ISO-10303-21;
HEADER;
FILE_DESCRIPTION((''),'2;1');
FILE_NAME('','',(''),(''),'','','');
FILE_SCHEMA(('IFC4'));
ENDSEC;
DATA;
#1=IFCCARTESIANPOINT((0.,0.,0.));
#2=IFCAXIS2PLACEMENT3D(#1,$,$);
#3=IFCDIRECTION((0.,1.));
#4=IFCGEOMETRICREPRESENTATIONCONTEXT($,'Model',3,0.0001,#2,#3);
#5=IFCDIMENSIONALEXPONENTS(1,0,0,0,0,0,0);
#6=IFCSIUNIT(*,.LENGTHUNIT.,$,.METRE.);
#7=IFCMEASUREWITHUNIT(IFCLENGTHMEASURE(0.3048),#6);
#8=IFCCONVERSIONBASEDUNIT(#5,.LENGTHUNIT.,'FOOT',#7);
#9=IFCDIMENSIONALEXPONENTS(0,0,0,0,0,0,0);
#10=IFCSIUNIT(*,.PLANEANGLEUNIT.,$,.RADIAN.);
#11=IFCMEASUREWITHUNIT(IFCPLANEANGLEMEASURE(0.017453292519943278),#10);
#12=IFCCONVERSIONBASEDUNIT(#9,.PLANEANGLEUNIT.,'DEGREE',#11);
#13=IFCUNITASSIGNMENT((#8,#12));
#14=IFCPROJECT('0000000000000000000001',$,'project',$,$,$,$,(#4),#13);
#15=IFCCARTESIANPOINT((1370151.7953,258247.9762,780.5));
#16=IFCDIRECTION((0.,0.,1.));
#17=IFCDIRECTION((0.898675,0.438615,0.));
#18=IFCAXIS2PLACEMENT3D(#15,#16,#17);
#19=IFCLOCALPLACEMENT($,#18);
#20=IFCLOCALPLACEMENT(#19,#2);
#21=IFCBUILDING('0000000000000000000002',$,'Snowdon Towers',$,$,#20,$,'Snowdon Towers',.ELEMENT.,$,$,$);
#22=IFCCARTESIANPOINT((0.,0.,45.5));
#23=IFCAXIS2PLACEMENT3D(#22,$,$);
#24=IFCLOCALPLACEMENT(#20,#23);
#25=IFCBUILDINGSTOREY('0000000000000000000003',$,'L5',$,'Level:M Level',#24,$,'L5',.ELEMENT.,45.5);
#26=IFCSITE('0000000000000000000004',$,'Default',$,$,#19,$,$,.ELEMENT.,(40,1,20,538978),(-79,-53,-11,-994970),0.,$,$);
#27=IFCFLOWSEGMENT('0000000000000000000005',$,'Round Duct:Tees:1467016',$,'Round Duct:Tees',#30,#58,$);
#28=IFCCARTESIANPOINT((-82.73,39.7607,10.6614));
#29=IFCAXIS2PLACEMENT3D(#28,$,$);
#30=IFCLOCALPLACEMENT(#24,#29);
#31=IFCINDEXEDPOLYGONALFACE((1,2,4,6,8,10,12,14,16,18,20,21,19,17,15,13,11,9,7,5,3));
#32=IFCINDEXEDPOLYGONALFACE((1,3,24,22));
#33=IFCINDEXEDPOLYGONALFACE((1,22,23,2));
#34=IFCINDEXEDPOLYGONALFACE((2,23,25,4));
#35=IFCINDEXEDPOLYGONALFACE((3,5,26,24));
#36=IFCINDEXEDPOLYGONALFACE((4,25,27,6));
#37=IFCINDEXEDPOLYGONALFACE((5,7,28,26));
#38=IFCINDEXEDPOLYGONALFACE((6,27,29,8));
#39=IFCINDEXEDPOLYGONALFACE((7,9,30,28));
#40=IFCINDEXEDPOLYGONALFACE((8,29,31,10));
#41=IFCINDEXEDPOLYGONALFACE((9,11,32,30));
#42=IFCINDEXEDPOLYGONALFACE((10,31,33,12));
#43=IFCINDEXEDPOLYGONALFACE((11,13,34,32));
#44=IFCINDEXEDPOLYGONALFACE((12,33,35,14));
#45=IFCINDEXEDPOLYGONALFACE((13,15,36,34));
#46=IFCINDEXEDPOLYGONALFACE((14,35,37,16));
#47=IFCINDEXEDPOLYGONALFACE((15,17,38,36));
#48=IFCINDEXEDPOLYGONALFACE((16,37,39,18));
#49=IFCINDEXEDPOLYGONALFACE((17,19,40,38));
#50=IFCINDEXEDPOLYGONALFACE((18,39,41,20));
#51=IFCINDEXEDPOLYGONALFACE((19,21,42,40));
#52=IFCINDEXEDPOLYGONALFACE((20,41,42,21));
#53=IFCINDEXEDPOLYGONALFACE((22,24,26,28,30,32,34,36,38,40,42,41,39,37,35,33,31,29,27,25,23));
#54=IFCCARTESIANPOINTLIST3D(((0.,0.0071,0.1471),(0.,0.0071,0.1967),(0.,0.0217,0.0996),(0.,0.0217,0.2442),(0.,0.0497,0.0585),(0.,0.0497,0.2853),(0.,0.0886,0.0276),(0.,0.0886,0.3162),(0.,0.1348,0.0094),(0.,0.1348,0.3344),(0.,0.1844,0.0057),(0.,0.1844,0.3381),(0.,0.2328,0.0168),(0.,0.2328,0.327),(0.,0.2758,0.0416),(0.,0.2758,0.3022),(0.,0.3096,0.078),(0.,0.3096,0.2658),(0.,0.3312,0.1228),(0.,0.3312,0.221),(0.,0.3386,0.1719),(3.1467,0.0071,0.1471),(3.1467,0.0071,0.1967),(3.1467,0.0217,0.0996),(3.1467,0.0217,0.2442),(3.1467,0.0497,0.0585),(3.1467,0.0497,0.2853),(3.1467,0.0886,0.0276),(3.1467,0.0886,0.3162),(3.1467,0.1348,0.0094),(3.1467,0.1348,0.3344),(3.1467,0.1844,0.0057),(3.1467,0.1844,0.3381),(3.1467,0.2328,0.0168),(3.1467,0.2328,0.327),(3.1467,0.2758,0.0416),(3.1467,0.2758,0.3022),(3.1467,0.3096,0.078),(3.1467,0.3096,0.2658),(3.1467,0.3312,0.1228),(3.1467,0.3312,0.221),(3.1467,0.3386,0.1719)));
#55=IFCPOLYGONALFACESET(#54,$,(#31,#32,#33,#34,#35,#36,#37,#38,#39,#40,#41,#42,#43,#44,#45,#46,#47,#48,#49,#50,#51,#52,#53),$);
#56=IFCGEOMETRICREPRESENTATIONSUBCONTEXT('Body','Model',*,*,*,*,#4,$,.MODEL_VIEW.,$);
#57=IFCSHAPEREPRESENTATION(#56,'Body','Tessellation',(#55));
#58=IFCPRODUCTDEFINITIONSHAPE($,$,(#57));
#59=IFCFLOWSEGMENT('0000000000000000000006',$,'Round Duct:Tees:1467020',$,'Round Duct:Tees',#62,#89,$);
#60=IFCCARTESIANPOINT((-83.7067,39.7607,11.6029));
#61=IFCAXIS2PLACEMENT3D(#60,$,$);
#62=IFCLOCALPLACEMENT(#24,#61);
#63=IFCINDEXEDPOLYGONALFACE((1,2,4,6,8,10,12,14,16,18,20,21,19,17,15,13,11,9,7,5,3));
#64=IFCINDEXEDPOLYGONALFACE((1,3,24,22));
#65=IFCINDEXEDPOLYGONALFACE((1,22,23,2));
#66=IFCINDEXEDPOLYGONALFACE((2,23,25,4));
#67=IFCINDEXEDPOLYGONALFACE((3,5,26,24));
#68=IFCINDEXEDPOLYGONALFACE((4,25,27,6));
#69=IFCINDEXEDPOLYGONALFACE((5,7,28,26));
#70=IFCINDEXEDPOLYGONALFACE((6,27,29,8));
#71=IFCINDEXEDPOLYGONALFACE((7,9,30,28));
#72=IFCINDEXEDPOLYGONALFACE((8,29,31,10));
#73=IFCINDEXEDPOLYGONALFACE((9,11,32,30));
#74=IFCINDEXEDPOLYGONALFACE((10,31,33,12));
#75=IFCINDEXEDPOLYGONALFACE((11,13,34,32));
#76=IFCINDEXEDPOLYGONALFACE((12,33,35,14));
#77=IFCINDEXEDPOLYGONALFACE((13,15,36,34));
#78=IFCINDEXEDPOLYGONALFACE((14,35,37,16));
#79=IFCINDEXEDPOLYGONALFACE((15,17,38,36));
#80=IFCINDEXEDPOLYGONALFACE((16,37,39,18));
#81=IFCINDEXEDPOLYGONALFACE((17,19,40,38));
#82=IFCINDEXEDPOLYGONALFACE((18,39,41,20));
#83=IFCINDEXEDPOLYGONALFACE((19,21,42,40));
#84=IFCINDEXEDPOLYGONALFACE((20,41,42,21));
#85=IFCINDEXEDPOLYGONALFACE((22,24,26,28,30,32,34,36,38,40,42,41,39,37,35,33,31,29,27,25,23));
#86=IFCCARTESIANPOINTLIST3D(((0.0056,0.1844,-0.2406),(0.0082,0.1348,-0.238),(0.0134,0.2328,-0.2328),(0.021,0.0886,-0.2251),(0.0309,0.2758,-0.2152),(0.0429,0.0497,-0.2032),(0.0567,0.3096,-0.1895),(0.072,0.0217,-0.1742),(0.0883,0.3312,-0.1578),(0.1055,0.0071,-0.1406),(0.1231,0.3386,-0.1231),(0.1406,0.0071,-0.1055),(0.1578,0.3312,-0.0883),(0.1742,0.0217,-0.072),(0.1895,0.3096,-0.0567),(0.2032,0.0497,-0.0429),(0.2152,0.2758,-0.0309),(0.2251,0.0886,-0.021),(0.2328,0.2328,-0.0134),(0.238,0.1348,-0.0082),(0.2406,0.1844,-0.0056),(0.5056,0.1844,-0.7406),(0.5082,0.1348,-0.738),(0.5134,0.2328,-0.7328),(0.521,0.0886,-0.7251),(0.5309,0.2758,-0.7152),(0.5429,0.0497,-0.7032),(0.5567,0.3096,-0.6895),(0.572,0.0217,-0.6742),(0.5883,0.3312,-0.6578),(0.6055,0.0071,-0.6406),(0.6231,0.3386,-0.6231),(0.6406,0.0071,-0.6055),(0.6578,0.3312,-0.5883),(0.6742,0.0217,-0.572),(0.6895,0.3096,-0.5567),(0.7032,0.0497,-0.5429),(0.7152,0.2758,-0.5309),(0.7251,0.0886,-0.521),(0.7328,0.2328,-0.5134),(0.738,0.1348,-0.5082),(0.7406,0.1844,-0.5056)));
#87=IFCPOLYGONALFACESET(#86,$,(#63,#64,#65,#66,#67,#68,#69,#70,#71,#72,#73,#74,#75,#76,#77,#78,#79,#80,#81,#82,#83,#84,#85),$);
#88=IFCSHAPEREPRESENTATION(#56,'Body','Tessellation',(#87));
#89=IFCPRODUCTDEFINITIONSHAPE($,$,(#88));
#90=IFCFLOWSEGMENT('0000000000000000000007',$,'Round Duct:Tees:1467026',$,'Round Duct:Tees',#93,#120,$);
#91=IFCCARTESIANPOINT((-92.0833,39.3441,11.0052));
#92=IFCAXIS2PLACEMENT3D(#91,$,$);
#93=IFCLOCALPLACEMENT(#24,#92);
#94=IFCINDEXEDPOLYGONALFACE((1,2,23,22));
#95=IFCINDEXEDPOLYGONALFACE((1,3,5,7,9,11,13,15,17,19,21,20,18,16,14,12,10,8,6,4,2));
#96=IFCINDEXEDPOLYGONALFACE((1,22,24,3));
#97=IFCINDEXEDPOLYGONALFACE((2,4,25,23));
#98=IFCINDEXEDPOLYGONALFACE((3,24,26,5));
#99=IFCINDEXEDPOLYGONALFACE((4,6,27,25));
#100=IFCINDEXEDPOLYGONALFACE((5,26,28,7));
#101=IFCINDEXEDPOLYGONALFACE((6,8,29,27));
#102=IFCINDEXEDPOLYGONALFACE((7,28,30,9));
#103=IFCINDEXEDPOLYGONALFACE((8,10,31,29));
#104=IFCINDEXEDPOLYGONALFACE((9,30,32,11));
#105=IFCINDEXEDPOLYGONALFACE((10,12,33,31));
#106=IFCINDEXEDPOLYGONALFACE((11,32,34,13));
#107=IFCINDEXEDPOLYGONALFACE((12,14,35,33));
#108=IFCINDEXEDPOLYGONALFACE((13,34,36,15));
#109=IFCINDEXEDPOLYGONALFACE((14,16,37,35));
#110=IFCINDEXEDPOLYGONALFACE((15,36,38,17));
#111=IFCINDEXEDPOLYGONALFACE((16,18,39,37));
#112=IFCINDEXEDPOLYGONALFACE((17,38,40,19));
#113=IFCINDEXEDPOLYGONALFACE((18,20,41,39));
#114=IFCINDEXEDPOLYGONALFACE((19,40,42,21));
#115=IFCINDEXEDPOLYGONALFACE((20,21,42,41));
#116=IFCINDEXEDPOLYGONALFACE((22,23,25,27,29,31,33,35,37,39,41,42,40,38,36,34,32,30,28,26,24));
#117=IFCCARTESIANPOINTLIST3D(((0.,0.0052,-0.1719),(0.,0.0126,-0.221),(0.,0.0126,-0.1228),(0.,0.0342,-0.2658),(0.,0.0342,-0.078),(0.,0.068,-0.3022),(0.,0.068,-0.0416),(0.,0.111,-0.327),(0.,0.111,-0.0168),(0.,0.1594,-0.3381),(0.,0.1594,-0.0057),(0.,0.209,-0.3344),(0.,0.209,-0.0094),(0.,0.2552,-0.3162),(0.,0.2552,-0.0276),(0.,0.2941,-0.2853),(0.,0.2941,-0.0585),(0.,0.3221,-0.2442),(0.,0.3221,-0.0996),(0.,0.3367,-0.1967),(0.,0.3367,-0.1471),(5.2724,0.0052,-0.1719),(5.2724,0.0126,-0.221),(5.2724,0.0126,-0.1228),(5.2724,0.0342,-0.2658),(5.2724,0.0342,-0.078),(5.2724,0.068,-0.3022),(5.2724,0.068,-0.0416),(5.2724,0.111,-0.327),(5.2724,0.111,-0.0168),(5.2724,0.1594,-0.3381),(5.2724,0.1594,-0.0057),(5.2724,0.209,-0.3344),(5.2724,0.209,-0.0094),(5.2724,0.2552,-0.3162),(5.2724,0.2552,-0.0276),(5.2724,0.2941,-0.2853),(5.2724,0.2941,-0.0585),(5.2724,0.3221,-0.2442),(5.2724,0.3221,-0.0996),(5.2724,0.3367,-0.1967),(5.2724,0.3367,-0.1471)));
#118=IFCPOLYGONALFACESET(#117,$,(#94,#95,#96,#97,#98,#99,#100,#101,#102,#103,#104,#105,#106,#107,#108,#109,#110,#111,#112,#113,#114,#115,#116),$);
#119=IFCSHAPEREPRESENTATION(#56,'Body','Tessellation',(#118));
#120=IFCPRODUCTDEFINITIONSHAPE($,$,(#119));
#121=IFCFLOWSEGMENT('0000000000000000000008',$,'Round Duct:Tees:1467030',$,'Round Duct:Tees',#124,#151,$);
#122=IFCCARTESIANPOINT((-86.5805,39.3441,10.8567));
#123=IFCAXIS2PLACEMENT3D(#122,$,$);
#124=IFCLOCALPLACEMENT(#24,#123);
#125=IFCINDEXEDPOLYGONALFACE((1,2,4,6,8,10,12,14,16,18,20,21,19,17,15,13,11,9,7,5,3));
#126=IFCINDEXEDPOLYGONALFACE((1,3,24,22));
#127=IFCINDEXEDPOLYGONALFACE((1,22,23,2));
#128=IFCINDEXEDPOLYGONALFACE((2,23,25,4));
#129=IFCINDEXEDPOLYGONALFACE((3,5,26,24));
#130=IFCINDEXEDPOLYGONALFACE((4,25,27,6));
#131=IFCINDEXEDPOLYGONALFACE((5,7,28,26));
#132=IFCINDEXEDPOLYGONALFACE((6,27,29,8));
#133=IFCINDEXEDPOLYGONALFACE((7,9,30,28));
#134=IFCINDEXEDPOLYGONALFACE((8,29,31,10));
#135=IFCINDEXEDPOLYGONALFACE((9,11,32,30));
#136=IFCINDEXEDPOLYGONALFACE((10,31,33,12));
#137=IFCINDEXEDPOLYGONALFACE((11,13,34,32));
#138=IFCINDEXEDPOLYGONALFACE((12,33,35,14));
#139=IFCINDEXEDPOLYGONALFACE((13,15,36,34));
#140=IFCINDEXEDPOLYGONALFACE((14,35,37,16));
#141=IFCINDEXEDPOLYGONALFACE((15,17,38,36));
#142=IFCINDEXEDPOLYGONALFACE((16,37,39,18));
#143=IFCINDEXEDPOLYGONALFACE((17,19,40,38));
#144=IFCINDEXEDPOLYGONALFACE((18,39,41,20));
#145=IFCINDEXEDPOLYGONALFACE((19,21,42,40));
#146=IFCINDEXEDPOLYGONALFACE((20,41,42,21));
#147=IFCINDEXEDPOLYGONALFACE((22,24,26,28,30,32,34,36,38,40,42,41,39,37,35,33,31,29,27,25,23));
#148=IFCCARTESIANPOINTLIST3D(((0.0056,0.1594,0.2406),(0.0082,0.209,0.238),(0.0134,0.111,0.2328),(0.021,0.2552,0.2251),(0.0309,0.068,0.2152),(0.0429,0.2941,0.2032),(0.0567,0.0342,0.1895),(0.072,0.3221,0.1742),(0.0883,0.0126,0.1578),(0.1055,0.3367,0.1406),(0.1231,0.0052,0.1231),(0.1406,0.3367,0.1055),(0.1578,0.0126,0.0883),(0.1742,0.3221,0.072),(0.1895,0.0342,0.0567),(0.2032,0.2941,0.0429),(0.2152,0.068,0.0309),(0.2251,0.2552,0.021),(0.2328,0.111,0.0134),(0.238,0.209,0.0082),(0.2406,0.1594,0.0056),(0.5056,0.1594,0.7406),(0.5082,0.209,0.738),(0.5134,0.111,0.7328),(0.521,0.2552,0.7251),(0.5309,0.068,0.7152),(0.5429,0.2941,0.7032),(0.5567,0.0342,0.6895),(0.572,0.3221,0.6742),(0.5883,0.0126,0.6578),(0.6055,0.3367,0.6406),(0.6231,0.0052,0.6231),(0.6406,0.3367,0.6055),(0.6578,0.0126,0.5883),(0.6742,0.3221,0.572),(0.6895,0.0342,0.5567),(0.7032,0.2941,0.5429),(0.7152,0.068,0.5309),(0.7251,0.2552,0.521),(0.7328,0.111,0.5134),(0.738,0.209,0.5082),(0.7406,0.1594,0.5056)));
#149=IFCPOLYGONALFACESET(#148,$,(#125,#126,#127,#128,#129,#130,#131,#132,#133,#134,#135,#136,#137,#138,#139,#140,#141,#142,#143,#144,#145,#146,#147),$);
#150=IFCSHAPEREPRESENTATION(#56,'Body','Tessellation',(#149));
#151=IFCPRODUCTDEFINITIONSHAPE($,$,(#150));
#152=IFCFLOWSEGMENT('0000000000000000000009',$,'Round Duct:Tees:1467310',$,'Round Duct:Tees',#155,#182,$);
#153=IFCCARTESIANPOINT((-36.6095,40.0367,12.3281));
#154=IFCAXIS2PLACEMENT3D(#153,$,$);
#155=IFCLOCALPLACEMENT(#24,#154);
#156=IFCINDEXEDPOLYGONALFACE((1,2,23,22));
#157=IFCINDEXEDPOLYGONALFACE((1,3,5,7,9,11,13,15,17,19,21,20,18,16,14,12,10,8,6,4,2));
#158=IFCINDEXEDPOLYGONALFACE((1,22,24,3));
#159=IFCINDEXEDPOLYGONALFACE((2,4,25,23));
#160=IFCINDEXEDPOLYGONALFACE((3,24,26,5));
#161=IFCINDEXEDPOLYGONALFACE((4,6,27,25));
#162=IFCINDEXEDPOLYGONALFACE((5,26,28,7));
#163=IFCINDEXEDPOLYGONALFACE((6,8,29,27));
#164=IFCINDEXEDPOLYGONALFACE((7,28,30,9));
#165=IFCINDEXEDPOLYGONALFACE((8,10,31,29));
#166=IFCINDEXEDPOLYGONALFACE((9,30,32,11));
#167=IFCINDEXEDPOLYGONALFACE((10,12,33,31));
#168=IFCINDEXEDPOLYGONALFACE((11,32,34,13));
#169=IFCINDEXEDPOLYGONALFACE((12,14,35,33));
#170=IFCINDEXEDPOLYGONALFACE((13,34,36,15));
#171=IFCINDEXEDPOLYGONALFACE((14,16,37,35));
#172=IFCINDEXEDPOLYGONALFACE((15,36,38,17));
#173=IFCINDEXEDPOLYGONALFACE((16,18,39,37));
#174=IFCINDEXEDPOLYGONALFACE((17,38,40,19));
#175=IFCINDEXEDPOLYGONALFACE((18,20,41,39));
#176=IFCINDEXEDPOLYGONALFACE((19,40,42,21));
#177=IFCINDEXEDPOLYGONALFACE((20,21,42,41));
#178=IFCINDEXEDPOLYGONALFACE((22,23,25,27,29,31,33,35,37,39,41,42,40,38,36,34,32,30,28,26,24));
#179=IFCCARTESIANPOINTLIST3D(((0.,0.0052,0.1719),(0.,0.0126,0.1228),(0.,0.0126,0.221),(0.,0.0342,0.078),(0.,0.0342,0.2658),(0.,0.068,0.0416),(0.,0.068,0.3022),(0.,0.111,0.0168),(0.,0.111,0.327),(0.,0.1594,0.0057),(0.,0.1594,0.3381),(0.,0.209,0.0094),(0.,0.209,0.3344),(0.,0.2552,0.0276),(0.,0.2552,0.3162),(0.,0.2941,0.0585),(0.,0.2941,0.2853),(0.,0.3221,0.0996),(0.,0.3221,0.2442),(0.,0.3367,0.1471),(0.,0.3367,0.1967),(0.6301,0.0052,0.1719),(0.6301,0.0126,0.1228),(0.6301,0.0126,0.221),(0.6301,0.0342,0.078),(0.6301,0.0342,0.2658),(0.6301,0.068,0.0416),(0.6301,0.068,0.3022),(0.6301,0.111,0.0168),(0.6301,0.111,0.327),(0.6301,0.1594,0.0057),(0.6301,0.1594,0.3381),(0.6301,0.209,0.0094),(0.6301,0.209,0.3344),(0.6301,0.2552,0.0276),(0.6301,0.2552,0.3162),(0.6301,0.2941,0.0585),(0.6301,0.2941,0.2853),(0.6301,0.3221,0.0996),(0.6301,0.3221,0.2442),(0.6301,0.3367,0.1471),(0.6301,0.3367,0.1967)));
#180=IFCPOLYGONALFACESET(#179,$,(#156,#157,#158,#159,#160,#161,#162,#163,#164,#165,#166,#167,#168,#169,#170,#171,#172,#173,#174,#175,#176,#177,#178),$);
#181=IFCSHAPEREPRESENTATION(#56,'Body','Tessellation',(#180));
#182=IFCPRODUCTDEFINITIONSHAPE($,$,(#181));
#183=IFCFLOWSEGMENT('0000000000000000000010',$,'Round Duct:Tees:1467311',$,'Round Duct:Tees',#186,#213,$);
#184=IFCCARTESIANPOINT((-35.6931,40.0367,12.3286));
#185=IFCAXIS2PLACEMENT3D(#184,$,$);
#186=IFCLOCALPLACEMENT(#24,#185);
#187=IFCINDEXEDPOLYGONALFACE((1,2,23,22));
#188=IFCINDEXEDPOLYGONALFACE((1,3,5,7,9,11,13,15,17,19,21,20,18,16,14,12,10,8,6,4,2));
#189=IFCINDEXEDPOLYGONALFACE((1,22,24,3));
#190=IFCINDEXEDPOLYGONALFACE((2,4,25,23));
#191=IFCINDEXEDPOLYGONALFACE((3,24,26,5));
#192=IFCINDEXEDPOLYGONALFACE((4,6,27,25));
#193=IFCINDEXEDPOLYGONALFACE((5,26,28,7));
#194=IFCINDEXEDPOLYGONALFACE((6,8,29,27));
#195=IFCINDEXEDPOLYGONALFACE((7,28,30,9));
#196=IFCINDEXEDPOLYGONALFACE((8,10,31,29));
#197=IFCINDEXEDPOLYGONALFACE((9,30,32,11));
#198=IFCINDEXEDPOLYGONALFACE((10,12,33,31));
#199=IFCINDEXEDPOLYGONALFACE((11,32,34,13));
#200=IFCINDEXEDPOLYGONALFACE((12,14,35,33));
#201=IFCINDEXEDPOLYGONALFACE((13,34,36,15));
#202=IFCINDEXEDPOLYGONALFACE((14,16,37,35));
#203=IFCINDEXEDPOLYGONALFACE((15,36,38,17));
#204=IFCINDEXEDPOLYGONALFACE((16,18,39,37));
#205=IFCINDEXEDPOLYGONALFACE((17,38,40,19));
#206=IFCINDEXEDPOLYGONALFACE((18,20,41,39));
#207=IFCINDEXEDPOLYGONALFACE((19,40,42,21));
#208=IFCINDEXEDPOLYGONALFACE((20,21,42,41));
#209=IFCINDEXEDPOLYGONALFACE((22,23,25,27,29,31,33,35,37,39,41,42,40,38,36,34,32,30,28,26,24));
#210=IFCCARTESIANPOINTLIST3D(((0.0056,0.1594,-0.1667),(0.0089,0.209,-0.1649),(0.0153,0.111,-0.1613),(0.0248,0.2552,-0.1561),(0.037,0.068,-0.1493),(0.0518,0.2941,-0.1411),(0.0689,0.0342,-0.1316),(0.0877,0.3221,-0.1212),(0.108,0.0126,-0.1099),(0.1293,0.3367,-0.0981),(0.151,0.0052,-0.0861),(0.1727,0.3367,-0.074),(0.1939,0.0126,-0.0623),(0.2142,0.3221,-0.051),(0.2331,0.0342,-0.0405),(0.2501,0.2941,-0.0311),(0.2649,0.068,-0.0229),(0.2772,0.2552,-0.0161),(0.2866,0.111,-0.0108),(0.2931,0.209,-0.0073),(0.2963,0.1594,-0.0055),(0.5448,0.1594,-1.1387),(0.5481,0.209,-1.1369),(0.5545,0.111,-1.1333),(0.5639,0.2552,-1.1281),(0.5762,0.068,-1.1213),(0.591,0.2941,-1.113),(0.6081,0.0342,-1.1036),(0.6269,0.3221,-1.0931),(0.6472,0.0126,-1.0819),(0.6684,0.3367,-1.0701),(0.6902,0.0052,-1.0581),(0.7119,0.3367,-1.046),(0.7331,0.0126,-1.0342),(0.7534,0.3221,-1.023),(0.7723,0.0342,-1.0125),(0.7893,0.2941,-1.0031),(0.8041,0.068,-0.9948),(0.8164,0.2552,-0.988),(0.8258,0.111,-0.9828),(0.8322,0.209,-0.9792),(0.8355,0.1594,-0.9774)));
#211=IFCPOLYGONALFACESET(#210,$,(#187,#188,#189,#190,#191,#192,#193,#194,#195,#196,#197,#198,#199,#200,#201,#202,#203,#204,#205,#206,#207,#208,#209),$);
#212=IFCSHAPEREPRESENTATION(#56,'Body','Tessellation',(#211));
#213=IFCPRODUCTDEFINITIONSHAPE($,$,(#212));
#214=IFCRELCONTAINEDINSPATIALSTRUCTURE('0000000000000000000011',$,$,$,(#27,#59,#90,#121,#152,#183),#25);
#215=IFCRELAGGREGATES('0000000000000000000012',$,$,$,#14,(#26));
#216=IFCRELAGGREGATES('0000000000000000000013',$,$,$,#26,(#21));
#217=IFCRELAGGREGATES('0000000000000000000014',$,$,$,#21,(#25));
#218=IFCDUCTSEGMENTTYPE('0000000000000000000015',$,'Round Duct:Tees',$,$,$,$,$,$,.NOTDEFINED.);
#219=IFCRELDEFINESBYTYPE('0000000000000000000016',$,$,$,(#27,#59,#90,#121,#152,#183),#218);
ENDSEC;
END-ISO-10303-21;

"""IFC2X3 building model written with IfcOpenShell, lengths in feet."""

from ifc_helpers import new_model, entity, si_unit, converted_unit, direction, frame, frame_2d, origin, origin_2d_with_axis, place, context, subcontext, project, spatial, circle, extrude, type_object, element, save


model = new_model("IFC2X3")

# Units and contexts
model_context = context("Model", 3, precision=0.0001, world=origin(), true_north=direction((0.0, 1.0)))
body_context = subcontext(model_context, "Body", "Model", "MODEL_VIEW")
ifc_project = project(units=[converted_unit("LENGTHUNIT", "FOOT", entity("IfcLengthMeasure", 0.3048), si_unit("LENGTHUNIT", "METRE"), dimensions=[1, 0, 0, 0, 0, 0, 0]), converted_unit("PLANEANGLEUNIT", "DEGREE", entity("IfcPlaneAngleMeasure", 0.017453292519943278), si_unit("PLANEANGLEUNIT", "RADIAN"), dimensions=[0, 0, 0, 0, 0, 0, 0])], contexts=[model_context])

# Site, building, storey
site_placement = place(None, frame((1370151.7953, 258247.9762, 780.5), z_axis=(0.0, 0.0, 1.0), x_axis=(0.898675, 0.438615, 0.0)))
site = spatial("IfcSite", under=ifc_project, at=site_placement, Name="Default", CompositionType="ELEMENT", RefLatitude=(40, 1, 20, 538978), RefLongitude=(-79, -53, -11, -994970), RefElevation=0.0)
building_placement = place(site_placement, origin())
building = spatial("IfcBuilding", under=site, at=building_placement, Name="Snowdon Towers", LongName="Snowdon Towers", CompositionType="ELEMENT")
storey_placement = place(building_placement, frame((0.0, 0.0, 45.5)))
storey = spatial("IfcBuildingStorey", under=building, at=storey_placement, Name="L5", ObjectType="Level:M Level", LongName="L5", CompositionType="ELEMENT", Elevation=45.5)

# Flow segments
duct_segment_type = type_object("IfcDuctSegmentType", Name="Round Duct:Tees", PredefinedType="NOTDEFINED")
flow_segment_1_placement = place(storey_placement, frame((-82.73, 39.7607, 10.6614)))
element("IfcFlowSegment", 1, at=flow_segment_1_placement, inside=storey, type_object=duct_segment_type, Name="Round Duct:Tees:1467016", ObjectType="Round Duct:Tees", context=body_context, shape_type="SweptSolid", body=[
    extrude(circle(Radius=0.1667, at=frame_2d((0.0, 0.0), x_axis=(1.0, 0.0))), frame((0.0, 0.1719, 0.1719), z_axis=(1.0, 0.0, 0.0), x_axis=(0.0, 1.0, 0.0)), (0.0, 0.0, 1.0), 3.1467),
])
flow_segment_2_placement = place(storey_placement, frame((-83.7067, 39.7607, 11.6029)))
element("IfcFlowSegment", 2, at=flow_segment_2_placement, inside=storey, type_object=duct_segment_type, Name="Round Duct:Tees:1467020", ObjectType="Round Duct:Tees", context=body_context, shape_type="SweptSolid", body=[
    extrude(circle(Radius=0.1667, at=frame_2d((0.0, 0.0), x_axis=(1.0, 0.0))), frame((0.1231, 0.1719, -0.1231), z_axis=(0.707107, 0.0, -0.707107), x_axis=(0.0, 1.0, 0.0)), (0.0, 0.0, 1.0), 0.7071),
])
flow_segment_3_placement = place(storey_placement, frame((-92.0833, 39.3441, 11.0052)))
element("IfcFlowSegment", 3, at=flow_segment_3_placement, inside=storey, type_object=duct_segment_type, Name="Round Duct:Tees:1467026", ObjectType="Round Duct:Tees", context=body_context, shape_type="SweptSolid", body=[
    extrude(circle(Radius=0.1667, at=origin_2d_with_axis()), frame((0.0, 0.1719, -0.1719), z_axis=(1.0, 0.0, 0.0), x_axis=(0.0, -1.0, 0.0)), (0.0, 0.0, 1.0), 5.2724),
])
flow_segment_4_placement = place(storey_placement, frame((-86.5805, 39.3441, 10.8567)))
element("IfcFlowSegment", 4, at=flow_segment_4_placement, inside=storey, type_object=duct_segment_type, Name="Round Duct:Tees:1467030", ObjectType="Round Duct:Tees", context=body_context, shape_type="SweptSolid", body=[
    extrude(circle(Radius=0.1667, at=origin_2d_with_axis()), frame((0.1231, 0.1719, 0.1231), z_axis=(0.707107, 0.0, 0.707107), x_axis=(0.0, -1.0, 0.0)), (0.0, 0.0, 1.0), 0.7071),
])
flow_segment_5_placement = place(storey_placement, frame((-36.6095, 40.0367, 12.3281)))
element("IfcFlowSegment", 5, at=flow_segment_5_placement, inside=storey, type_object=duct_segment_type, Name="Round Duct:Tees:1467310", ObjectType="Round Duct:Tees", context=body_context, shape_type="SweptSolid", body=[
    extrude(circle(Radius=0.1667, at=frame_2d((0.0, 0.0), x_axis=(1.0, 0.0))), frame((0.0, 0.1719, 0.1719), z_axis=(1.0, 0.0, 0.0), x_axis=(0.0, -1.0, 0.0)), (0.0, 0.0, 1.0), 0.6301),
])
flow_segment_6_placement = place(storey_placement, frame((-35.6931, 40.0367, 12.3286)))
element("IfcFlowSegment", 6, at=flow_segment_6_placement, inside=storey, type_object=duct_segment_type, Name="Round Duct:Tees:1467311", ObjectType="Round Duct:Tees", context=body_context, shape_type="SweptSolid", body=[
    extrude(circle(Radius=0.1667, at=origin_2d_with_axis()), frame((0.151, 0.1719, -0.0861), z_axis=(0.485085, 0.0, -0.874467), x_axis=(0.0, -1.0, 0.0)), (0.0, 0.0, 1.0), 1.1115),
])

save(model, "model.ifc")
